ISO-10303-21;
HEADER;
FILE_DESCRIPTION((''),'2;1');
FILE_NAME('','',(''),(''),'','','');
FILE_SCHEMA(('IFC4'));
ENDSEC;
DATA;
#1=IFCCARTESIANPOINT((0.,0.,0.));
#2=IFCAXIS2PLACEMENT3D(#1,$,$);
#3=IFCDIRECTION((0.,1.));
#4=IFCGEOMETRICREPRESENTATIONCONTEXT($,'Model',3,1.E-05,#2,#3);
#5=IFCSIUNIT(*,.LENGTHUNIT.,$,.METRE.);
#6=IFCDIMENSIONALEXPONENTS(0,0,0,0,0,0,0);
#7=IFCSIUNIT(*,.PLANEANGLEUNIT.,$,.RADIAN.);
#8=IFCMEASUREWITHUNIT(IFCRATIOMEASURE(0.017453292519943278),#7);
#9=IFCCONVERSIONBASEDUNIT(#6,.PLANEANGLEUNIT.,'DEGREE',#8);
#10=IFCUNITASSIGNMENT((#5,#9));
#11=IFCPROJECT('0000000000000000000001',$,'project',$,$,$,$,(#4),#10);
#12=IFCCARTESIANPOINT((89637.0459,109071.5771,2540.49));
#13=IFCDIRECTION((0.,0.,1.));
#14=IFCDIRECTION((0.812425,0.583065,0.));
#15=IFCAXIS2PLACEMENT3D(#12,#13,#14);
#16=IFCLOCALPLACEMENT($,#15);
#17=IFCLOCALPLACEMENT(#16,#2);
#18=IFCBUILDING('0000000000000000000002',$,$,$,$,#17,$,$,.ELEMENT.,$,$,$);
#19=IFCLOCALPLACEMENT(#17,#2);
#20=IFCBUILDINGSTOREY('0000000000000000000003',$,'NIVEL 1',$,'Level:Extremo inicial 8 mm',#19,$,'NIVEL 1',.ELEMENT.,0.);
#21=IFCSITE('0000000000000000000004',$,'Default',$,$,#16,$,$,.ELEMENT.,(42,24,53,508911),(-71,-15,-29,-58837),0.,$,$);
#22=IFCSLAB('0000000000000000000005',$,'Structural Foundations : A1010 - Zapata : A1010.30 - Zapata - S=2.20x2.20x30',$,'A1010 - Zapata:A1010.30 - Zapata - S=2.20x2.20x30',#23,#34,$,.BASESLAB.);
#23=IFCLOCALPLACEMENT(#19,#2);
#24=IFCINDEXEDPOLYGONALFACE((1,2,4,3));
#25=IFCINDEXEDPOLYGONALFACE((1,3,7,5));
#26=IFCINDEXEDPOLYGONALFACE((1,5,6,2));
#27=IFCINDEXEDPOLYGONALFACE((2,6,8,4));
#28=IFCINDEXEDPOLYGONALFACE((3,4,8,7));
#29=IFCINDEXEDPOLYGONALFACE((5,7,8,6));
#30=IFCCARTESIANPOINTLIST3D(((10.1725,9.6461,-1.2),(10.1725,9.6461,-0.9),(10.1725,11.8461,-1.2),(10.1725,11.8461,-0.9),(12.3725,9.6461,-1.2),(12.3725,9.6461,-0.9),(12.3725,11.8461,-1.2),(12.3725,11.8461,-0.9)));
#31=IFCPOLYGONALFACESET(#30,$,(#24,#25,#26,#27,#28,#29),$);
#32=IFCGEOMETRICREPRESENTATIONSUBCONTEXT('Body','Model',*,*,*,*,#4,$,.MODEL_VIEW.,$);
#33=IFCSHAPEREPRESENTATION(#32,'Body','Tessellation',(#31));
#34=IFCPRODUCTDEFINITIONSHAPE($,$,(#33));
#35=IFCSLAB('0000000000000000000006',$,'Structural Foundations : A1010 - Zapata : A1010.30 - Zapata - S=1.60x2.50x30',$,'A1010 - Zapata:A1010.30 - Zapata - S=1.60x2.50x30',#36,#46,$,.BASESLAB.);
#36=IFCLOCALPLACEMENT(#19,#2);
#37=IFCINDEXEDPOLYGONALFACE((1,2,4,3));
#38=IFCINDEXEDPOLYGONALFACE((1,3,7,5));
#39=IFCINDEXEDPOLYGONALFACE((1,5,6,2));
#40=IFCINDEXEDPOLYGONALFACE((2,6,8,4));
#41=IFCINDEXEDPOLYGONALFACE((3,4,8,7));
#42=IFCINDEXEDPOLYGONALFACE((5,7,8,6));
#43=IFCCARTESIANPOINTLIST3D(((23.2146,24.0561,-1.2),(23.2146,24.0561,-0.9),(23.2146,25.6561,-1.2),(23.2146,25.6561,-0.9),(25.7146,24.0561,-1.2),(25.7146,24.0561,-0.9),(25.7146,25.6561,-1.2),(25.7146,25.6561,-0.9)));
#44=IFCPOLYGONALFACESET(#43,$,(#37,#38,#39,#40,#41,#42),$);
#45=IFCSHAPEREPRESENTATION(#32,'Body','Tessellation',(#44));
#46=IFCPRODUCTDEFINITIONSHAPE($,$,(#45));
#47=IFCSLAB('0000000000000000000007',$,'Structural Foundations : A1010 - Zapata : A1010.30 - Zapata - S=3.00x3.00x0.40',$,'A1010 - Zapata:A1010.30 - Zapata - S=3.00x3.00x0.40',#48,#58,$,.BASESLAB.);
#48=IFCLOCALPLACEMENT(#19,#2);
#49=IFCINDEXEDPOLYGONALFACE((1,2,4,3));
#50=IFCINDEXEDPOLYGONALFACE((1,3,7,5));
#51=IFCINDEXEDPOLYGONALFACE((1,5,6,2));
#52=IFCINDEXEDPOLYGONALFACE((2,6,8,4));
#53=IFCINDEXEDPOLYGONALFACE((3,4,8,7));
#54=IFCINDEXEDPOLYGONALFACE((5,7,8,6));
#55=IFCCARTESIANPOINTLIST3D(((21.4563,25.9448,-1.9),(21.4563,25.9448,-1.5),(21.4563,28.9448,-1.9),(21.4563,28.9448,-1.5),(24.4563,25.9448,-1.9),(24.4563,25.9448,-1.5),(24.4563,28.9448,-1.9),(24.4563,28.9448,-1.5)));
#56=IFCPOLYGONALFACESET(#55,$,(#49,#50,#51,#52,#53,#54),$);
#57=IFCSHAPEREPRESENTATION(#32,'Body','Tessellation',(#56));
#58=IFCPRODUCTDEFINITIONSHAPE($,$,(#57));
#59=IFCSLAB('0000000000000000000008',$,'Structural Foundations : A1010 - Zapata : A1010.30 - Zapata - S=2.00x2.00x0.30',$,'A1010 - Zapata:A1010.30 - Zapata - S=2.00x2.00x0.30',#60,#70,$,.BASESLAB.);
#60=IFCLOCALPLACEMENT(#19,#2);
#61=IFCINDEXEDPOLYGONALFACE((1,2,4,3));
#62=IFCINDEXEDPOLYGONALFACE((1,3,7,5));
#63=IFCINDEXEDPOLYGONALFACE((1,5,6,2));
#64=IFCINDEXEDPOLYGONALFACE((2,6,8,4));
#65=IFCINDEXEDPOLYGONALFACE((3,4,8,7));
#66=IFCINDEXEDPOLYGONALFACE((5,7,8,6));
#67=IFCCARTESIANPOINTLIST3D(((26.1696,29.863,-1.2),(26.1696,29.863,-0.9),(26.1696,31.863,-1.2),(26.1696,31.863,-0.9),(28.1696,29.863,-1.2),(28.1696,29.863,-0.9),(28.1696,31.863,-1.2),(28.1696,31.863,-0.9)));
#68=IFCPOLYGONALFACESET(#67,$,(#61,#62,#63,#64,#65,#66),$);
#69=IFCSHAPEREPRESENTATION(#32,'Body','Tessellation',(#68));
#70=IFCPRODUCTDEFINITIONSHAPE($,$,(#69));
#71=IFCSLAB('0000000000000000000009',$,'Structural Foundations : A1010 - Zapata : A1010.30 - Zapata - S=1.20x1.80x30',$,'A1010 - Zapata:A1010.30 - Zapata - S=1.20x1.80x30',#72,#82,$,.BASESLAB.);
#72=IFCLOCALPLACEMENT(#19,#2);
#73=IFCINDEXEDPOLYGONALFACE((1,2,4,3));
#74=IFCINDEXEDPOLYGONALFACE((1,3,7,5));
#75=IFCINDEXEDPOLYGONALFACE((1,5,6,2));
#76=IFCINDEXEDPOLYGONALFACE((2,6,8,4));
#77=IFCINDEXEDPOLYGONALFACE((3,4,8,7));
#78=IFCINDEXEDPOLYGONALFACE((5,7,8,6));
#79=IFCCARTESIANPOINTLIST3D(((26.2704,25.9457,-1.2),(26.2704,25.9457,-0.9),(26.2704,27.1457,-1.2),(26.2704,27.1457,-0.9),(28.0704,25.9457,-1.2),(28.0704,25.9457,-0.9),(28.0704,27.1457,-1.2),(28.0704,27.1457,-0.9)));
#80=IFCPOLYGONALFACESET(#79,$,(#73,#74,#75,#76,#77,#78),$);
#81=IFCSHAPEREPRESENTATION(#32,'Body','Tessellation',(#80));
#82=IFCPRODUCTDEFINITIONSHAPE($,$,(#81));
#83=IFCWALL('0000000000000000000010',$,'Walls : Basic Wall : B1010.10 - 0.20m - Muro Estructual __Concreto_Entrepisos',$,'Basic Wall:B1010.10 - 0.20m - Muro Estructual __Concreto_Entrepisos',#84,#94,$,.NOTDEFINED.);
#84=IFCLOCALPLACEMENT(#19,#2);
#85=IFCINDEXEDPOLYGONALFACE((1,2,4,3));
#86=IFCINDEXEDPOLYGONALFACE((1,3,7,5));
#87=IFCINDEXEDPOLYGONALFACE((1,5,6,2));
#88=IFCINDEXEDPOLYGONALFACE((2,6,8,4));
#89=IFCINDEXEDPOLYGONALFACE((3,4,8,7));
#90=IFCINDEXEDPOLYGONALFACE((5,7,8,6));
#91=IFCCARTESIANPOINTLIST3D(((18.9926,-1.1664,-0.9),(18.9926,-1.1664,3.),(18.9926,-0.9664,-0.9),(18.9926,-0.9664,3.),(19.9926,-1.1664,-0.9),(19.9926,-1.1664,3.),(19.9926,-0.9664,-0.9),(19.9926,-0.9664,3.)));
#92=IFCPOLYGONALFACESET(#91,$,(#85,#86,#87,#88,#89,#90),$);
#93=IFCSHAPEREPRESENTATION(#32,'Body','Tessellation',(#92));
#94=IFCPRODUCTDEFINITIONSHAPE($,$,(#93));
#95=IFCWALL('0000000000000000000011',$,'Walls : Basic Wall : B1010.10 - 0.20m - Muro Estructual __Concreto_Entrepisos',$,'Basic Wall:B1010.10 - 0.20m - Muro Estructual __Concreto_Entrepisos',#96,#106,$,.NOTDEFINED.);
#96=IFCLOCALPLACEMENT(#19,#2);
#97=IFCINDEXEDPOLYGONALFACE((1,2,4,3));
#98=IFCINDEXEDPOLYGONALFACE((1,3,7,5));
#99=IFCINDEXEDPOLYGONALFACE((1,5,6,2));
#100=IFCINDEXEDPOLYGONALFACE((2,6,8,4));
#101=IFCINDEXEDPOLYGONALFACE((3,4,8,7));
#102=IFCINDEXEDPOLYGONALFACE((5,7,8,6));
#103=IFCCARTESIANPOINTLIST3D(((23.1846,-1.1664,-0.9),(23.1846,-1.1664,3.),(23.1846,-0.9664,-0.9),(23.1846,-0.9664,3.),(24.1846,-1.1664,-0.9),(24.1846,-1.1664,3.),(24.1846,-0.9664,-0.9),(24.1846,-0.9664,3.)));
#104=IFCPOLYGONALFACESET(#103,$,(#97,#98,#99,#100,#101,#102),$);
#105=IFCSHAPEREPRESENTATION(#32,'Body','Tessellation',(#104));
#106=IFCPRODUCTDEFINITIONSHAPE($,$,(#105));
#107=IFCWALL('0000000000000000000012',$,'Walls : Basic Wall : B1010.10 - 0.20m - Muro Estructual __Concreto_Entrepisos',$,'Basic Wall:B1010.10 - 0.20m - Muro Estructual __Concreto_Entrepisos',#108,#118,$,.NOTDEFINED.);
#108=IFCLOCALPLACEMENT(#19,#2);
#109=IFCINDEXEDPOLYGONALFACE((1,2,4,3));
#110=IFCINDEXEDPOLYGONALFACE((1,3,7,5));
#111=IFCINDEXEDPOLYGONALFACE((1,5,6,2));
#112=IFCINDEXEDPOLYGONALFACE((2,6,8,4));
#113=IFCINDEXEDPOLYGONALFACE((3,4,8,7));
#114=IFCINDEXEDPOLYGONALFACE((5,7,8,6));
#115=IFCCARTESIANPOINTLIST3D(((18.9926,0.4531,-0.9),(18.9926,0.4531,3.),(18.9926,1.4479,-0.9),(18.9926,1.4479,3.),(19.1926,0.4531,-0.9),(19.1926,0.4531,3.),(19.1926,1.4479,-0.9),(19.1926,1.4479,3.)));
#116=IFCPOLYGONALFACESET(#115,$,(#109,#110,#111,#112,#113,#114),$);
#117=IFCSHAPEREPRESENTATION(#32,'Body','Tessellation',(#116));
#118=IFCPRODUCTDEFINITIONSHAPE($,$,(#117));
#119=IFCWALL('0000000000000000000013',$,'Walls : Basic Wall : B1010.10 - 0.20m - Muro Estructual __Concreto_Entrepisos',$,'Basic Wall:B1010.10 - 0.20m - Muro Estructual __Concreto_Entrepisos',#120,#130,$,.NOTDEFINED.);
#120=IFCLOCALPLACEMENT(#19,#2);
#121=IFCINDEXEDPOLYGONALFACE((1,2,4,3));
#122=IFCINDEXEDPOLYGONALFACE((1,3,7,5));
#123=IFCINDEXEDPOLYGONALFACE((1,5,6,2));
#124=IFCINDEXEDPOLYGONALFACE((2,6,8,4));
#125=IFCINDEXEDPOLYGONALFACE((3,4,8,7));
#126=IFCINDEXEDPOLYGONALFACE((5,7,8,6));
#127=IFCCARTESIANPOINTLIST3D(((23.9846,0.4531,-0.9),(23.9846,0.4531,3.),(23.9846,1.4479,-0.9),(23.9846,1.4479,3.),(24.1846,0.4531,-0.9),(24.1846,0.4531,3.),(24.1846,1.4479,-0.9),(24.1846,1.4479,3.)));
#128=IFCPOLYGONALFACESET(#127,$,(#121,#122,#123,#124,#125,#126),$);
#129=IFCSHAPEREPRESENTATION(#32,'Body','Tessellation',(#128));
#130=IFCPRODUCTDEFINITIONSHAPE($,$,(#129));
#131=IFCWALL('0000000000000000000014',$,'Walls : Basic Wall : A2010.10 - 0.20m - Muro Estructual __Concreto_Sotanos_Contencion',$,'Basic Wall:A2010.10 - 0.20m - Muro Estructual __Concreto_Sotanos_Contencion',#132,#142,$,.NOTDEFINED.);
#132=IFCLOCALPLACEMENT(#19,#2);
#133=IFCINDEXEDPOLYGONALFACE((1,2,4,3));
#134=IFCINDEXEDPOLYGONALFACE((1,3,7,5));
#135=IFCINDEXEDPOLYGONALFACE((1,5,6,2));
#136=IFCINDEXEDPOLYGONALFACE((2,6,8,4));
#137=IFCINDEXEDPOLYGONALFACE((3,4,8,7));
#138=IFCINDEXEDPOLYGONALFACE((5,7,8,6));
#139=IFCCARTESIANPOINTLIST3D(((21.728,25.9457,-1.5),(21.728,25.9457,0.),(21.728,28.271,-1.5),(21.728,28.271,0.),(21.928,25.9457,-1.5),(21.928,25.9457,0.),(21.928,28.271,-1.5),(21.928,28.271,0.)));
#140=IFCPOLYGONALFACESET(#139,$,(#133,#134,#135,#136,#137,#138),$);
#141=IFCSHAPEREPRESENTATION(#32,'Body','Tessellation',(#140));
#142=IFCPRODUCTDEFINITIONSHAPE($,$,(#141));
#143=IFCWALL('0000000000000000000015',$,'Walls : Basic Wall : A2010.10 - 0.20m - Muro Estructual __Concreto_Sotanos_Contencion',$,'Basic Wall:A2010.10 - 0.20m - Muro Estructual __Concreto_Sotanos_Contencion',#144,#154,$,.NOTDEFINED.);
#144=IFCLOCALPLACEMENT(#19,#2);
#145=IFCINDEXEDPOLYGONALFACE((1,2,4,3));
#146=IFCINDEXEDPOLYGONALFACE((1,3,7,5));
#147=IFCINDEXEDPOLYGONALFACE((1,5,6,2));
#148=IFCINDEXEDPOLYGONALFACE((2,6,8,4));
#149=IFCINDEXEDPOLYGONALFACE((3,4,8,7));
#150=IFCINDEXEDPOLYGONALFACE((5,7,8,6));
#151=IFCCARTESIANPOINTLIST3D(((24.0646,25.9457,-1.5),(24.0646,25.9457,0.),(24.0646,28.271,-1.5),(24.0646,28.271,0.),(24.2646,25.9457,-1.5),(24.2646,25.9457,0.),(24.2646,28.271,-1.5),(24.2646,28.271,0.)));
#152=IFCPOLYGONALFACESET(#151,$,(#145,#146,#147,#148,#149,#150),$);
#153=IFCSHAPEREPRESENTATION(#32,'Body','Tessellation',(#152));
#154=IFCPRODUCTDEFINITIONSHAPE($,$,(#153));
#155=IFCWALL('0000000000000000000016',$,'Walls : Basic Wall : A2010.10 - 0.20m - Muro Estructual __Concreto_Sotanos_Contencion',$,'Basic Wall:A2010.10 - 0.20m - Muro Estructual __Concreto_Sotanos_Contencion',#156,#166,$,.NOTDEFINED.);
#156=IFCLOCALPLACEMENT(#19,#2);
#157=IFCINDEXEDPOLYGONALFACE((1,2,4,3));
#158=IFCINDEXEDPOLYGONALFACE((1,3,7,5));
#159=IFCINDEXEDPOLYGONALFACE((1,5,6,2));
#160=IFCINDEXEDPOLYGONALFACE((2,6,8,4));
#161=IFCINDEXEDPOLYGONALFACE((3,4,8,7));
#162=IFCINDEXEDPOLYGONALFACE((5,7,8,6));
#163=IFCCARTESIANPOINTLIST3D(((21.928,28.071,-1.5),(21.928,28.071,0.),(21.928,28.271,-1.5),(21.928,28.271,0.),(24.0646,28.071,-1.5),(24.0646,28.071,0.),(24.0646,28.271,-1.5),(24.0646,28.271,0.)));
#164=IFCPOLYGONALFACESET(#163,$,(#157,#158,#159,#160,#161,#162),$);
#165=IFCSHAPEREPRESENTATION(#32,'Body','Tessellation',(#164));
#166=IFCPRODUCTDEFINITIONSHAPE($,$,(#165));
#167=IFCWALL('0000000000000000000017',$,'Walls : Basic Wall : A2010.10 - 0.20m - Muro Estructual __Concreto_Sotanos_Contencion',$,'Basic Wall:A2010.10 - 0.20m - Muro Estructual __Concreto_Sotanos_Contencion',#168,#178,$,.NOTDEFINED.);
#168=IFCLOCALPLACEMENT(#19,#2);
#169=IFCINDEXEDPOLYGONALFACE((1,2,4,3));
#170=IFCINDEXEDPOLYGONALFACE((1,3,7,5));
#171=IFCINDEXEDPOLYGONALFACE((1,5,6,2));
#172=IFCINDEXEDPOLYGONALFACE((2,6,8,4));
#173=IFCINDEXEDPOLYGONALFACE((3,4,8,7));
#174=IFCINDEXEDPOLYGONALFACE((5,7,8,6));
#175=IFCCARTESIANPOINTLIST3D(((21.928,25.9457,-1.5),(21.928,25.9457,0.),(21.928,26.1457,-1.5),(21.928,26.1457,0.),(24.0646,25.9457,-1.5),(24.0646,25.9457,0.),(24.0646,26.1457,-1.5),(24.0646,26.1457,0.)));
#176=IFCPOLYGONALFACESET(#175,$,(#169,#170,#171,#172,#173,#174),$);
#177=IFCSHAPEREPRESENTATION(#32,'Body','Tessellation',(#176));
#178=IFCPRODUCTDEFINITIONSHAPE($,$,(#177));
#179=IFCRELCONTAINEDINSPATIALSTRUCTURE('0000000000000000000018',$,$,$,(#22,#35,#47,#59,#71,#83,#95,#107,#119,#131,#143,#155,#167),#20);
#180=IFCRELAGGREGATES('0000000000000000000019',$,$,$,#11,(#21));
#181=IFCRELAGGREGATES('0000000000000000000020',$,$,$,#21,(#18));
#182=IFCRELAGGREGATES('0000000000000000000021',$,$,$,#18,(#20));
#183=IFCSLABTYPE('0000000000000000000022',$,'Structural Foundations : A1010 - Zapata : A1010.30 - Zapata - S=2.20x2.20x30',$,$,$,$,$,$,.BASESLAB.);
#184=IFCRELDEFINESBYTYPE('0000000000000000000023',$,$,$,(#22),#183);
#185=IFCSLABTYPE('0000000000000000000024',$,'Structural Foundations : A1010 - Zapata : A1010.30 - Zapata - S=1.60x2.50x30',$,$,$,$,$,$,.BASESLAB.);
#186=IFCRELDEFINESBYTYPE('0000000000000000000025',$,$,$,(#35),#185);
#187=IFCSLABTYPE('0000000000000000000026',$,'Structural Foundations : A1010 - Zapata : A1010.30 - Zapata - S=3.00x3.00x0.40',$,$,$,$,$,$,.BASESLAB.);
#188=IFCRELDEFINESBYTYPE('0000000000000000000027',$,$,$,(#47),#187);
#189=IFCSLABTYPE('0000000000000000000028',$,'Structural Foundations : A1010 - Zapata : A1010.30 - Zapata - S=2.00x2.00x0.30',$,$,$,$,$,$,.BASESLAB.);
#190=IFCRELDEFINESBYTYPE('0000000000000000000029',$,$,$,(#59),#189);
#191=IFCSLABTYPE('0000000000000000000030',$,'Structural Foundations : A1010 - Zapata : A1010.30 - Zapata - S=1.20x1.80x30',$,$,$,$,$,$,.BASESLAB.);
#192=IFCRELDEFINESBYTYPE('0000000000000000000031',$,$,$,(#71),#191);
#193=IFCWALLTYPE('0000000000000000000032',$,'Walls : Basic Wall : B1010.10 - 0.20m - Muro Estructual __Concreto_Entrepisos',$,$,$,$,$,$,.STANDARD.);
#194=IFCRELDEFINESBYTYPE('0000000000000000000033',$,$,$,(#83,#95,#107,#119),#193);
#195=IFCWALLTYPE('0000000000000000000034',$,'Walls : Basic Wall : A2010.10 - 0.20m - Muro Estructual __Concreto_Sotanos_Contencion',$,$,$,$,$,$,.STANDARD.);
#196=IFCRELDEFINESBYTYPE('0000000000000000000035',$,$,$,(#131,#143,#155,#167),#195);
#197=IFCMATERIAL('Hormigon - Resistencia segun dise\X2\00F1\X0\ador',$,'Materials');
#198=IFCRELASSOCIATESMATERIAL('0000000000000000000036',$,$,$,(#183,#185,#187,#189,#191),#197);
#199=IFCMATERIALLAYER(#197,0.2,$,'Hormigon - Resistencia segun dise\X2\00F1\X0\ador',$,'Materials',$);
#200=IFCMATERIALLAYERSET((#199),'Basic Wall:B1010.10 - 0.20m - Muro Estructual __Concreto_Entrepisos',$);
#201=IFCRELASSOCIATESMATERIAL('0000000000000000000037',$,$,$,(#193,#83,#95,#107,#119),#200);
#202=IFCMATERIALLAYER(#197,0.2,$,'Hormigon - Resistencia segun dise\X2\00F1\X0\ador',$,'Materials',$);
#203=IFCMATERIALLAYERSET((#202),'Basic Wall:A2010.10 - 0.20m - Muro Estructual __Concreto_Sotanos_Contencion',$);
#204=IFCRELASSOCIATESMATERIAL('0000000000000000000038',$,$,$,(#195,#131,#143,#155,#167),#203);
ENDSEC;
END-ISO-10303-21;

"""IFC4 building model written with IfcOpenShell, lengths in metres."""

from ifc_helpers import new_model, entity, si_unit, converted_unit, direction, frame, frame_2d, origin, origin_2d_with_axis, place, context, subcontext, project, spatial, rectangle, extrude, material, layer, layer_set, layer_usage, type_object, element, save


model = new_model("IFC4")

# Units and contexts
model_context = context("Model", 3, precision=1e-05, world=origin(), true_north=direction((0.0, 1.0)))
body_context = subcontext(model_context, "Body", "Model", "MODEL_VIEW")
ifc_project = project(units=[si_unit("LENGTHUNIT", "METRE"), converted_unit("PLANEANGLEUNIT", "DEGREE", entity("IfcRatioMeasure", 0.017453292519943278), si_unit("PLANEANGLEUNIT", "RADIAN"), dimensions=[0, 0, 0, 0, 0, 0, 0])], contexts=[model_context])

# Site, building, storey
site_placement = place(None, frame((89637.0459, 109071.5771, 2540.49), z_axis=(0.0, 0.0, 1.0), x_axis=(0.812425, 0.583065, 0.0)))
site = spatial("IfcSite", under=ifc_project, at=site_placement, Name="Default", CompositionType="ELEMENT", RefLatitude=(42, 24, 53, 508911), RefLongitude=(-71, -15, -29, -58837), RefElevation=0.0)
building_placement = place(site_placement, origin())
building = spatial("IfcBuilding", under=site, at=building_placement, CompositionType="ELEMENT")
storey_placement = place(building_placement, origin())
storey = spatial("IfcBuildingStorey", under=building, at=storey_placement, Name="NIVEL 1", ObjectType="Level:Extremo inicial 8 mm", LongName="NIVEL 1", CompositionType="ELEMENT", Elevation=0.0)

# Slabs
ifc_material_1 = material(Name="Hormigon - Resistencia segun diseñador", Category="Materials")
slab_type_1 = type_object("IfcSlabType", Name="Structural Foundations : A1010 - Zapata : A1010.30 - Zapata - S=2.20x2.20x30", PredefinedType="BASESLAB", material=ifc_material_1)
slab_1_placement = place(storey_placement, frame((10.1725, 9.6461, -1.2)))
element("IfcSlab", 1, at=slab_1_placement, inside=storey, type_object=slab_type_1, Name="Structural Foundations : A1010 - Zapata : A1010.30 - Zapata - S=2.20x2.20x30", ObjectType="A1010 - Zapata:A1010.30 - Zapata - S=2.20x2.20x30", PredefinedType="BASESLAB", context=body_context, shape_type="SweptSolid", body=[
    extrude(rectangle(XDim=2.2, YDim=2.2, at=frame_2d((0.0, 0.0), x_axis=(1.0, 0.0))), frame((1.1, 1.1, 0.0), z_axis=(0.0, 0.0, 1.0), x_axis=(-1.0, 0.0, 0.0)), (0.0, 0.0, 1.0), 0.3),
])
slab_type_2 = type_object("IfcSlabType", Name="Structural Foundations : A1010 - Zapata : A1010.30 - Zapata - S=1.60x2.50x30", PredefinedType="BASESLAB", material=ifc_material_1)
slab_2_placement = place(storey_placement, frame((23.2146, 24.0561, -1.2)))
element("IfcSlab", 2, at=slab_2_placement, inside=storey, type_object=slab_type_2, Name="Structural Foundations : A1010 - Zapata : A1010.30 - Zapata - S=1.60x2.50x30", ObjectType="A1010 - Zapata:A1010.30 - Zapata - S=1.60x2.50x30", PredefinedType="BASESLAB", context=body_context, shape_type="SweptSolid", body=[
    extrude(rectangle(XDim=1.6, YDim=2.5, at=frame_2d((0.0, 0.0), x_axis=(1.0, 0.0))), frame((1.25, 0.8, 0.0), z_axis=(0.0, 0.0, 1.0), x_axis=(0.0, -1.0, 0.0)), (0.0, 0.0, 1.0), 0.3),
])
slab_type_3 = type_object("IfcSlabType", Name="Structural Foundations : A1010 - Zapata : A1010.30 - Zapata - S=3.00x3.00x0.40", PredefinedType="BASESLAB", material=ifc_material_1)
slab_3_placement = place(storey_placement, frame((21.4563, 25.9448, -1.9)))
element("IfcSlab", 3, at=slab_3_placement, inside=storey, type_object=slab_type_3, Name="Structural Foundations : A1010 - Zapata : A1010.30 - Zapata - S=3.00x3.00x0.40", ObjectType="A1010 - Zapata:A1010.30 - Zapata - S=3.00x3.00x0.40", PredefinedType="BASESLAB", context=body_context, shape_type="SweptSolid", body=[
    extrude(rectangle(XDim=3.0, YDim=3.0, at=origin_2d_with_axis()), frame((1.5, 1.5, 0.0), z_axis=(0.0, 0.0, 1.0), x_axis=(0.0, -1.0, 0.0)), (0.0, 0.0, 1.0), 0.4),
])
slab_type_4 = type_object("IfcSlabType", Name="Structural Foundations : A1010 - Zapata : A1010.30 - Zapata - S=2.00x2.00x0.30", PredefinedType="BASESLAB", material=ifc_material_1)
slab_4_placement = place(storey_placement, frame((26.1696, 29.863, -1.2)))
element("IfcSlab", 4, at=slab_4_placement, inside=storey, type_object=slab_type_4, Name="Structural Foundations : A1010 - Zapata : A1010.30 - Zapata - S=2.00x2.00x0.30", ObjectType="A1010 - Zapata:A1010.30 - Zapata - S=2.00x2.00x0.30", PredefinedType="BASESLAB", context=body_context, shape_type="SweptSolid", body=[
    extrude(rectangle(XDim=2.0, YDim=2.0, at=origin_2d_with_axis()), frame((1.0, 1.0, 0.0), z_axis=(0.0, 0.0, 1.0), x_axis=(0.0, -1.0, 0.0)), (0.0, 0.0, 1.0), 0.3),
])
slab_type_5 = type_object("IfcSlabType", Name="Structural Foundations : A1010 - Zapata : A1010.30 - Zapata - S=1.20x1.80x30", PredefinedType="BASESLAB", material=ifc_material_1)
slab_5_placement = place(storey_placement, frame((26.2704, 25.9457, -1.2)))
element("IfcSlab", 5, at=slab_5_placement, inside=storey, type_object=slab_type_5, Name="Structural Foundations : A1010 - Zapata : A1010.30 - Zapata - S=1.20x1.80x30", ObjectType="A1010 - Zapata:A1010.30 - Zapata - S=1.20x1.80x30", PredefinedType="BASESLAB", context=body_context, shape_type="SweptSolid", body=[
    extrude(rectangle(XDim=1.2, YDim=1.8, at=frame_2d((0.0, 0.0), x_axis=(1.0, 0.0))), frame((0.9, 0.6, 0.0), z_axis=(0.0, 0.0, 1.0), x_axis=(0.0, -1.0, 0.0)), (0.0, 0.0, 1.0), 0.3),
])

# Walls
ifc_layer_1 = layer(ifc_material_1, 0.2, Name="Hormigon - Resistencia segun diseñador", Category="Materials")
ifc_layer_set_1 = layer_set([ifc_layer_1], Name="Basic Wall:B1010.10 - 0.20m - Muro Estructual __Concreto_Entrepisos")
ifc_layer_usage_1 = layer_usage(ifc_layer_set_1, "AXIS2", "NEGATIVE", 0.1)
wall_type_1 = type_object("IfcWallType", Name="Walls : Basic Wall : B1010.10 - 0.20m - Muro Estructual __Concreto_Entrepisos", PredefinedType="STANDARD", material=ifc_layer_set_1)
wall_1_placement = place(storey_placement, frame((18.9926, -1.0664, -0.9)))
element("IfcWall", 6, at=wall_1_placement, inside=storey, type_object=wall_type_1, material=ifc_layer_usage_1, Name="Walls : Basic Wall : B1010.10 - 0.20m - Muro Estructual __Concreto_Entrepisos", ObjectType="Basic Wall:B1010.10 - 0.20m - Muro Estructual __Concreto_Entrepisos", PredefinedType="NOTDEFINED", context=body_context, shape_type="SweptSolid", body=[
    extrude(rectangle(XDim=1.0, YDim=0.2, at=frame_2d((0.5, 0.0), x_axis=(-1.0, 0.0))), origin(), (0.0, 0.0, 1.0), 3.9),
])
ifc_layer_usage_2 = layer_usage(ifc_layer_set_1, "AXIS2", "NEGATIVE", 0.1)
wall_2_placement = place(storey_placement, frame((23.1846, -1.0664, -0.9)))
element("IfcWall", 7, at=wall_2_placement, inside=storey, type_object=wall_type_1, material=ifc_layer_usage_2, Name="Walls : Basic Wall : B1010.10 - 0.20m - Muro Estructual __Concreto_Entrepisos", ObjectType="Basic Wall:B1010.10 - 0.20m - Muro Estructual __Concreto_Entrepisos", PredefinedType="NOTDEFINED", context=body_context, shape_type="SweptSolid", body=[
    extrude(rectangle(XDim=1.0, YDim=0.2, at=frame_2d((0.5, 0.0), x_axis=(-1.0, 0.0))), origin(), (0.0, 0.0, 1.0), 3.9),
])
ifc_layer_usage_3 = layer_usage(ifc_layer_set_1, "AXIS2", "NEGATIVE", 0.1)
wall_3_placement = place(storey_placement, frame((19.0926, 0.4531, -0.9), z_axis=(0.0, 0.0, 1.0), x_axis=(0.0, 1.0, 0.0)))
element("IfcWall", 8, at=wall_3_placement, inside=storey, type_object=wall_type_1, material=ifc_layer_usage_3, Name="Walls : Basic Wall : B1010.10 - 0.20m - Muro Estructual __Concreto_Entrepisos", ObjectType="Basic Wall:B1010.10 - 0.20m - Muro Estructual __Concreto_Entrepisos", PredefinedType="NOTDEFINED", context=body_context, shape_type="SweptSolid", body=[
    extrude(rectangle(XDim=0.9948, YDim=0.2, at=frame_2d((0.4974, 0.0), x_axis=(-1.0, 0.0))), origin(), (0.0, 0.0, 1.0), 3.9),
])
ifc_layer_usage_4 = layer_usage(ifc_layer_set_1, "AXIS2", "NEGATIVE", 0.1)
wall_4_placement = place(storey_placement, frame((24.0846, 0.4531, -0.9), z_axis=(0.0, 0.0, 1.0), x_axis=(0.0, 1.0, 0.0)))
element("IfcWall", 9, at=wall_4_placement, inside=storey, type_object=wall_type_1, material=ifc_layer_usage_4, Name="Walls : Basic Wall : B1010.10 - 0.20m - Muro Estructual __Concreto_Entrepisos", ObjectType="Basic Wall:B1010.10 - 0.20m - Muro Estructual __Concreto_Entrepisos", PredefinedType="NOTDEFINED", context=body_context, shape_type="SweptSolid", body=[
    extrude(rectangle(XDim=0.9948, YDim=0.2, at=frame_2d((0.4974, 0.0), x_axis=(-1.0, 0.0))), origin(), (0.0, 0.0, 1.0), 3.9),
])
ifc_layer_2 = layer(ifc_material_1, 0.2, Name="Hormigon - Resistencia segun diseñador", Category="Materials")
ifc_layer_set_2 = layer_set([ifc_layer_2], Name="Basic Wall:A2010.10 - 0.20m - Muro Estructual __Concreto_Sotanos_Contencion")
ifc_layer_usage_5 = layer_usage(ifc_layer_set_2, "AXIS2", "NEGATIVE", 0.1)
wall_type_2 = type_object("IfcWallType", Name="Walls : Basic Wall : A2010.10 - 0.20m - Muro Estructual __Concreto_Sotanos_Contencion", PredefinedType="STANDARD", material=ifc_layer_set_2)
wall_5_placement = place(storey_placement, frame((21.828, 28.271, -1.5), z_axis=(0.0, 0.0, 1.0), x_axis=(0.0, -1.0, 0.0)))
element("IfcWall", 10, at=wall_5_placement, inside=storey, type_object=wall_type_2, material=ifc_layer_usage_5, Name="Walls : Basic Wall : A2010.10 - 0.20m - Muro Estructual __Concreto_Sotanos_Contencion", ObjectType="Basic Wall:A2010.10 - 0.20m - Muro Estructual __Concreto_Sotanos_Contencion", PredefinedType="NOTDEFINED", context=body_context, shape_type="SweptSolid", body=[
    extrude(rectangle(XDim=2.3253, YDim=0.2, at=frame_2d((1.1626, 0.0), x_axis=(-1.0, 0.0))), origin(), (0.0, 0.0, 1.0), 1.5),
])
ifc_layer_usage_6 = layer_usage(ifc_layer_set_2, "AXIS2", "NEGATIVE", 0.1)
wall_6_placement = place(storey_placement, frame((24.1646, 28.271, -1.5), z_axis=(0.0, 0.0, 1.0), x_axis=(0.0, -1.0, 0.0)))
element("IfcWall", 11, at=wall_6_placement, inside=storey, type_object=wall_type_2, material=ifc_layer_usage_6, Name="Walls : Basic Wall : A2010.10 - 0.20m - Muro Estructual __Concreto_Sotanos_Contencion", ObjectType="Basic Wall:A2010.10 - 0.20m - Muro Estructual __Concreto_Sotanos_Contencion", PredefinedType="NOTDEFINED", context=body_context, shape_type="SweptSolid", body=[
    extrude(rectangle(XDim=2.3253, YDim=0.2, at=frame_2d((1.1626, 0.0), x_axis=(-1.0, 0.0))), origin(), (0.0, 0.0, 1.0), 1.5),
])
ifc_layer_usage_7 = layer_usage(ifc_layer_set_2, "AXIS2", "NEGATIVE", 0.1)
wall_7_placement = place(storey_placement, frame((24.0646, 28.171, -1.5), z_axis=(0.0, 0.0, 1.0), x_axis=(-1.0, 0.0, 0.0)))
element("IfcWall", 12, at=wall_7_placement, inside=storey, type_object=wall_type_2, material=ifc_layer_usage_7, Name="Walls : Basic Wall : A2010.10 - 0.20m - Muro Estructual __Concreto_Sotanos_Contencion", ObjectType="Basic Wall:A2010.10 - 0.20m - Muro Estructual __Concreto_Sotanos_Contencion", PredefinedType="NOTDEFINED", context=body_context, shape_type="SweptSolid", body=[
    extrude(rectangle(XDim=2.1366, YDim=0.2, at=frame_2d((1.0683, 0.0), x_axis=(-1.0, 0.0))), origin(), (0.0, 0.0, 1.0), 1.5),
])
ifc_layer_usage_8 = layer_usage(ifc_layer_set_2, "AXIS2", "NEGATIVE", 0.1)
wall_8_placement = place(storey_placement, frame((24.0646, 26.0457, -1.5), z_axis=(0.0, 0.0, 1.0), x_axis=(-1.0, 0.0, 0.0)))
element("IfcWall", 13, at=wall_8_placement, inside=storey, type_object=wall_type_2, material=ifc_layer_usage_8, Name="Walls : Basic Wall : A2010.10 - 0.20m - Muro Estructual __Concreto_Sotanos_Contencion", ObjectType="Basic Wall:A2010.10 - 0.20m - Muro Estructual __Concreto_Sotanos_Contencion", PredefinedType="NOTDEFINED", context=body_context, shape_type="SweptSolid", body=[
    extrude(rectangle(XDim=2.1366, YDim=0.2, at=frame_2d((1.0683, 0.0), x_axis=(-1.0, 0.0))), origin(), (0.0, 0.0, 1.0), 1.5),
])

save(model, "model.ifc")
